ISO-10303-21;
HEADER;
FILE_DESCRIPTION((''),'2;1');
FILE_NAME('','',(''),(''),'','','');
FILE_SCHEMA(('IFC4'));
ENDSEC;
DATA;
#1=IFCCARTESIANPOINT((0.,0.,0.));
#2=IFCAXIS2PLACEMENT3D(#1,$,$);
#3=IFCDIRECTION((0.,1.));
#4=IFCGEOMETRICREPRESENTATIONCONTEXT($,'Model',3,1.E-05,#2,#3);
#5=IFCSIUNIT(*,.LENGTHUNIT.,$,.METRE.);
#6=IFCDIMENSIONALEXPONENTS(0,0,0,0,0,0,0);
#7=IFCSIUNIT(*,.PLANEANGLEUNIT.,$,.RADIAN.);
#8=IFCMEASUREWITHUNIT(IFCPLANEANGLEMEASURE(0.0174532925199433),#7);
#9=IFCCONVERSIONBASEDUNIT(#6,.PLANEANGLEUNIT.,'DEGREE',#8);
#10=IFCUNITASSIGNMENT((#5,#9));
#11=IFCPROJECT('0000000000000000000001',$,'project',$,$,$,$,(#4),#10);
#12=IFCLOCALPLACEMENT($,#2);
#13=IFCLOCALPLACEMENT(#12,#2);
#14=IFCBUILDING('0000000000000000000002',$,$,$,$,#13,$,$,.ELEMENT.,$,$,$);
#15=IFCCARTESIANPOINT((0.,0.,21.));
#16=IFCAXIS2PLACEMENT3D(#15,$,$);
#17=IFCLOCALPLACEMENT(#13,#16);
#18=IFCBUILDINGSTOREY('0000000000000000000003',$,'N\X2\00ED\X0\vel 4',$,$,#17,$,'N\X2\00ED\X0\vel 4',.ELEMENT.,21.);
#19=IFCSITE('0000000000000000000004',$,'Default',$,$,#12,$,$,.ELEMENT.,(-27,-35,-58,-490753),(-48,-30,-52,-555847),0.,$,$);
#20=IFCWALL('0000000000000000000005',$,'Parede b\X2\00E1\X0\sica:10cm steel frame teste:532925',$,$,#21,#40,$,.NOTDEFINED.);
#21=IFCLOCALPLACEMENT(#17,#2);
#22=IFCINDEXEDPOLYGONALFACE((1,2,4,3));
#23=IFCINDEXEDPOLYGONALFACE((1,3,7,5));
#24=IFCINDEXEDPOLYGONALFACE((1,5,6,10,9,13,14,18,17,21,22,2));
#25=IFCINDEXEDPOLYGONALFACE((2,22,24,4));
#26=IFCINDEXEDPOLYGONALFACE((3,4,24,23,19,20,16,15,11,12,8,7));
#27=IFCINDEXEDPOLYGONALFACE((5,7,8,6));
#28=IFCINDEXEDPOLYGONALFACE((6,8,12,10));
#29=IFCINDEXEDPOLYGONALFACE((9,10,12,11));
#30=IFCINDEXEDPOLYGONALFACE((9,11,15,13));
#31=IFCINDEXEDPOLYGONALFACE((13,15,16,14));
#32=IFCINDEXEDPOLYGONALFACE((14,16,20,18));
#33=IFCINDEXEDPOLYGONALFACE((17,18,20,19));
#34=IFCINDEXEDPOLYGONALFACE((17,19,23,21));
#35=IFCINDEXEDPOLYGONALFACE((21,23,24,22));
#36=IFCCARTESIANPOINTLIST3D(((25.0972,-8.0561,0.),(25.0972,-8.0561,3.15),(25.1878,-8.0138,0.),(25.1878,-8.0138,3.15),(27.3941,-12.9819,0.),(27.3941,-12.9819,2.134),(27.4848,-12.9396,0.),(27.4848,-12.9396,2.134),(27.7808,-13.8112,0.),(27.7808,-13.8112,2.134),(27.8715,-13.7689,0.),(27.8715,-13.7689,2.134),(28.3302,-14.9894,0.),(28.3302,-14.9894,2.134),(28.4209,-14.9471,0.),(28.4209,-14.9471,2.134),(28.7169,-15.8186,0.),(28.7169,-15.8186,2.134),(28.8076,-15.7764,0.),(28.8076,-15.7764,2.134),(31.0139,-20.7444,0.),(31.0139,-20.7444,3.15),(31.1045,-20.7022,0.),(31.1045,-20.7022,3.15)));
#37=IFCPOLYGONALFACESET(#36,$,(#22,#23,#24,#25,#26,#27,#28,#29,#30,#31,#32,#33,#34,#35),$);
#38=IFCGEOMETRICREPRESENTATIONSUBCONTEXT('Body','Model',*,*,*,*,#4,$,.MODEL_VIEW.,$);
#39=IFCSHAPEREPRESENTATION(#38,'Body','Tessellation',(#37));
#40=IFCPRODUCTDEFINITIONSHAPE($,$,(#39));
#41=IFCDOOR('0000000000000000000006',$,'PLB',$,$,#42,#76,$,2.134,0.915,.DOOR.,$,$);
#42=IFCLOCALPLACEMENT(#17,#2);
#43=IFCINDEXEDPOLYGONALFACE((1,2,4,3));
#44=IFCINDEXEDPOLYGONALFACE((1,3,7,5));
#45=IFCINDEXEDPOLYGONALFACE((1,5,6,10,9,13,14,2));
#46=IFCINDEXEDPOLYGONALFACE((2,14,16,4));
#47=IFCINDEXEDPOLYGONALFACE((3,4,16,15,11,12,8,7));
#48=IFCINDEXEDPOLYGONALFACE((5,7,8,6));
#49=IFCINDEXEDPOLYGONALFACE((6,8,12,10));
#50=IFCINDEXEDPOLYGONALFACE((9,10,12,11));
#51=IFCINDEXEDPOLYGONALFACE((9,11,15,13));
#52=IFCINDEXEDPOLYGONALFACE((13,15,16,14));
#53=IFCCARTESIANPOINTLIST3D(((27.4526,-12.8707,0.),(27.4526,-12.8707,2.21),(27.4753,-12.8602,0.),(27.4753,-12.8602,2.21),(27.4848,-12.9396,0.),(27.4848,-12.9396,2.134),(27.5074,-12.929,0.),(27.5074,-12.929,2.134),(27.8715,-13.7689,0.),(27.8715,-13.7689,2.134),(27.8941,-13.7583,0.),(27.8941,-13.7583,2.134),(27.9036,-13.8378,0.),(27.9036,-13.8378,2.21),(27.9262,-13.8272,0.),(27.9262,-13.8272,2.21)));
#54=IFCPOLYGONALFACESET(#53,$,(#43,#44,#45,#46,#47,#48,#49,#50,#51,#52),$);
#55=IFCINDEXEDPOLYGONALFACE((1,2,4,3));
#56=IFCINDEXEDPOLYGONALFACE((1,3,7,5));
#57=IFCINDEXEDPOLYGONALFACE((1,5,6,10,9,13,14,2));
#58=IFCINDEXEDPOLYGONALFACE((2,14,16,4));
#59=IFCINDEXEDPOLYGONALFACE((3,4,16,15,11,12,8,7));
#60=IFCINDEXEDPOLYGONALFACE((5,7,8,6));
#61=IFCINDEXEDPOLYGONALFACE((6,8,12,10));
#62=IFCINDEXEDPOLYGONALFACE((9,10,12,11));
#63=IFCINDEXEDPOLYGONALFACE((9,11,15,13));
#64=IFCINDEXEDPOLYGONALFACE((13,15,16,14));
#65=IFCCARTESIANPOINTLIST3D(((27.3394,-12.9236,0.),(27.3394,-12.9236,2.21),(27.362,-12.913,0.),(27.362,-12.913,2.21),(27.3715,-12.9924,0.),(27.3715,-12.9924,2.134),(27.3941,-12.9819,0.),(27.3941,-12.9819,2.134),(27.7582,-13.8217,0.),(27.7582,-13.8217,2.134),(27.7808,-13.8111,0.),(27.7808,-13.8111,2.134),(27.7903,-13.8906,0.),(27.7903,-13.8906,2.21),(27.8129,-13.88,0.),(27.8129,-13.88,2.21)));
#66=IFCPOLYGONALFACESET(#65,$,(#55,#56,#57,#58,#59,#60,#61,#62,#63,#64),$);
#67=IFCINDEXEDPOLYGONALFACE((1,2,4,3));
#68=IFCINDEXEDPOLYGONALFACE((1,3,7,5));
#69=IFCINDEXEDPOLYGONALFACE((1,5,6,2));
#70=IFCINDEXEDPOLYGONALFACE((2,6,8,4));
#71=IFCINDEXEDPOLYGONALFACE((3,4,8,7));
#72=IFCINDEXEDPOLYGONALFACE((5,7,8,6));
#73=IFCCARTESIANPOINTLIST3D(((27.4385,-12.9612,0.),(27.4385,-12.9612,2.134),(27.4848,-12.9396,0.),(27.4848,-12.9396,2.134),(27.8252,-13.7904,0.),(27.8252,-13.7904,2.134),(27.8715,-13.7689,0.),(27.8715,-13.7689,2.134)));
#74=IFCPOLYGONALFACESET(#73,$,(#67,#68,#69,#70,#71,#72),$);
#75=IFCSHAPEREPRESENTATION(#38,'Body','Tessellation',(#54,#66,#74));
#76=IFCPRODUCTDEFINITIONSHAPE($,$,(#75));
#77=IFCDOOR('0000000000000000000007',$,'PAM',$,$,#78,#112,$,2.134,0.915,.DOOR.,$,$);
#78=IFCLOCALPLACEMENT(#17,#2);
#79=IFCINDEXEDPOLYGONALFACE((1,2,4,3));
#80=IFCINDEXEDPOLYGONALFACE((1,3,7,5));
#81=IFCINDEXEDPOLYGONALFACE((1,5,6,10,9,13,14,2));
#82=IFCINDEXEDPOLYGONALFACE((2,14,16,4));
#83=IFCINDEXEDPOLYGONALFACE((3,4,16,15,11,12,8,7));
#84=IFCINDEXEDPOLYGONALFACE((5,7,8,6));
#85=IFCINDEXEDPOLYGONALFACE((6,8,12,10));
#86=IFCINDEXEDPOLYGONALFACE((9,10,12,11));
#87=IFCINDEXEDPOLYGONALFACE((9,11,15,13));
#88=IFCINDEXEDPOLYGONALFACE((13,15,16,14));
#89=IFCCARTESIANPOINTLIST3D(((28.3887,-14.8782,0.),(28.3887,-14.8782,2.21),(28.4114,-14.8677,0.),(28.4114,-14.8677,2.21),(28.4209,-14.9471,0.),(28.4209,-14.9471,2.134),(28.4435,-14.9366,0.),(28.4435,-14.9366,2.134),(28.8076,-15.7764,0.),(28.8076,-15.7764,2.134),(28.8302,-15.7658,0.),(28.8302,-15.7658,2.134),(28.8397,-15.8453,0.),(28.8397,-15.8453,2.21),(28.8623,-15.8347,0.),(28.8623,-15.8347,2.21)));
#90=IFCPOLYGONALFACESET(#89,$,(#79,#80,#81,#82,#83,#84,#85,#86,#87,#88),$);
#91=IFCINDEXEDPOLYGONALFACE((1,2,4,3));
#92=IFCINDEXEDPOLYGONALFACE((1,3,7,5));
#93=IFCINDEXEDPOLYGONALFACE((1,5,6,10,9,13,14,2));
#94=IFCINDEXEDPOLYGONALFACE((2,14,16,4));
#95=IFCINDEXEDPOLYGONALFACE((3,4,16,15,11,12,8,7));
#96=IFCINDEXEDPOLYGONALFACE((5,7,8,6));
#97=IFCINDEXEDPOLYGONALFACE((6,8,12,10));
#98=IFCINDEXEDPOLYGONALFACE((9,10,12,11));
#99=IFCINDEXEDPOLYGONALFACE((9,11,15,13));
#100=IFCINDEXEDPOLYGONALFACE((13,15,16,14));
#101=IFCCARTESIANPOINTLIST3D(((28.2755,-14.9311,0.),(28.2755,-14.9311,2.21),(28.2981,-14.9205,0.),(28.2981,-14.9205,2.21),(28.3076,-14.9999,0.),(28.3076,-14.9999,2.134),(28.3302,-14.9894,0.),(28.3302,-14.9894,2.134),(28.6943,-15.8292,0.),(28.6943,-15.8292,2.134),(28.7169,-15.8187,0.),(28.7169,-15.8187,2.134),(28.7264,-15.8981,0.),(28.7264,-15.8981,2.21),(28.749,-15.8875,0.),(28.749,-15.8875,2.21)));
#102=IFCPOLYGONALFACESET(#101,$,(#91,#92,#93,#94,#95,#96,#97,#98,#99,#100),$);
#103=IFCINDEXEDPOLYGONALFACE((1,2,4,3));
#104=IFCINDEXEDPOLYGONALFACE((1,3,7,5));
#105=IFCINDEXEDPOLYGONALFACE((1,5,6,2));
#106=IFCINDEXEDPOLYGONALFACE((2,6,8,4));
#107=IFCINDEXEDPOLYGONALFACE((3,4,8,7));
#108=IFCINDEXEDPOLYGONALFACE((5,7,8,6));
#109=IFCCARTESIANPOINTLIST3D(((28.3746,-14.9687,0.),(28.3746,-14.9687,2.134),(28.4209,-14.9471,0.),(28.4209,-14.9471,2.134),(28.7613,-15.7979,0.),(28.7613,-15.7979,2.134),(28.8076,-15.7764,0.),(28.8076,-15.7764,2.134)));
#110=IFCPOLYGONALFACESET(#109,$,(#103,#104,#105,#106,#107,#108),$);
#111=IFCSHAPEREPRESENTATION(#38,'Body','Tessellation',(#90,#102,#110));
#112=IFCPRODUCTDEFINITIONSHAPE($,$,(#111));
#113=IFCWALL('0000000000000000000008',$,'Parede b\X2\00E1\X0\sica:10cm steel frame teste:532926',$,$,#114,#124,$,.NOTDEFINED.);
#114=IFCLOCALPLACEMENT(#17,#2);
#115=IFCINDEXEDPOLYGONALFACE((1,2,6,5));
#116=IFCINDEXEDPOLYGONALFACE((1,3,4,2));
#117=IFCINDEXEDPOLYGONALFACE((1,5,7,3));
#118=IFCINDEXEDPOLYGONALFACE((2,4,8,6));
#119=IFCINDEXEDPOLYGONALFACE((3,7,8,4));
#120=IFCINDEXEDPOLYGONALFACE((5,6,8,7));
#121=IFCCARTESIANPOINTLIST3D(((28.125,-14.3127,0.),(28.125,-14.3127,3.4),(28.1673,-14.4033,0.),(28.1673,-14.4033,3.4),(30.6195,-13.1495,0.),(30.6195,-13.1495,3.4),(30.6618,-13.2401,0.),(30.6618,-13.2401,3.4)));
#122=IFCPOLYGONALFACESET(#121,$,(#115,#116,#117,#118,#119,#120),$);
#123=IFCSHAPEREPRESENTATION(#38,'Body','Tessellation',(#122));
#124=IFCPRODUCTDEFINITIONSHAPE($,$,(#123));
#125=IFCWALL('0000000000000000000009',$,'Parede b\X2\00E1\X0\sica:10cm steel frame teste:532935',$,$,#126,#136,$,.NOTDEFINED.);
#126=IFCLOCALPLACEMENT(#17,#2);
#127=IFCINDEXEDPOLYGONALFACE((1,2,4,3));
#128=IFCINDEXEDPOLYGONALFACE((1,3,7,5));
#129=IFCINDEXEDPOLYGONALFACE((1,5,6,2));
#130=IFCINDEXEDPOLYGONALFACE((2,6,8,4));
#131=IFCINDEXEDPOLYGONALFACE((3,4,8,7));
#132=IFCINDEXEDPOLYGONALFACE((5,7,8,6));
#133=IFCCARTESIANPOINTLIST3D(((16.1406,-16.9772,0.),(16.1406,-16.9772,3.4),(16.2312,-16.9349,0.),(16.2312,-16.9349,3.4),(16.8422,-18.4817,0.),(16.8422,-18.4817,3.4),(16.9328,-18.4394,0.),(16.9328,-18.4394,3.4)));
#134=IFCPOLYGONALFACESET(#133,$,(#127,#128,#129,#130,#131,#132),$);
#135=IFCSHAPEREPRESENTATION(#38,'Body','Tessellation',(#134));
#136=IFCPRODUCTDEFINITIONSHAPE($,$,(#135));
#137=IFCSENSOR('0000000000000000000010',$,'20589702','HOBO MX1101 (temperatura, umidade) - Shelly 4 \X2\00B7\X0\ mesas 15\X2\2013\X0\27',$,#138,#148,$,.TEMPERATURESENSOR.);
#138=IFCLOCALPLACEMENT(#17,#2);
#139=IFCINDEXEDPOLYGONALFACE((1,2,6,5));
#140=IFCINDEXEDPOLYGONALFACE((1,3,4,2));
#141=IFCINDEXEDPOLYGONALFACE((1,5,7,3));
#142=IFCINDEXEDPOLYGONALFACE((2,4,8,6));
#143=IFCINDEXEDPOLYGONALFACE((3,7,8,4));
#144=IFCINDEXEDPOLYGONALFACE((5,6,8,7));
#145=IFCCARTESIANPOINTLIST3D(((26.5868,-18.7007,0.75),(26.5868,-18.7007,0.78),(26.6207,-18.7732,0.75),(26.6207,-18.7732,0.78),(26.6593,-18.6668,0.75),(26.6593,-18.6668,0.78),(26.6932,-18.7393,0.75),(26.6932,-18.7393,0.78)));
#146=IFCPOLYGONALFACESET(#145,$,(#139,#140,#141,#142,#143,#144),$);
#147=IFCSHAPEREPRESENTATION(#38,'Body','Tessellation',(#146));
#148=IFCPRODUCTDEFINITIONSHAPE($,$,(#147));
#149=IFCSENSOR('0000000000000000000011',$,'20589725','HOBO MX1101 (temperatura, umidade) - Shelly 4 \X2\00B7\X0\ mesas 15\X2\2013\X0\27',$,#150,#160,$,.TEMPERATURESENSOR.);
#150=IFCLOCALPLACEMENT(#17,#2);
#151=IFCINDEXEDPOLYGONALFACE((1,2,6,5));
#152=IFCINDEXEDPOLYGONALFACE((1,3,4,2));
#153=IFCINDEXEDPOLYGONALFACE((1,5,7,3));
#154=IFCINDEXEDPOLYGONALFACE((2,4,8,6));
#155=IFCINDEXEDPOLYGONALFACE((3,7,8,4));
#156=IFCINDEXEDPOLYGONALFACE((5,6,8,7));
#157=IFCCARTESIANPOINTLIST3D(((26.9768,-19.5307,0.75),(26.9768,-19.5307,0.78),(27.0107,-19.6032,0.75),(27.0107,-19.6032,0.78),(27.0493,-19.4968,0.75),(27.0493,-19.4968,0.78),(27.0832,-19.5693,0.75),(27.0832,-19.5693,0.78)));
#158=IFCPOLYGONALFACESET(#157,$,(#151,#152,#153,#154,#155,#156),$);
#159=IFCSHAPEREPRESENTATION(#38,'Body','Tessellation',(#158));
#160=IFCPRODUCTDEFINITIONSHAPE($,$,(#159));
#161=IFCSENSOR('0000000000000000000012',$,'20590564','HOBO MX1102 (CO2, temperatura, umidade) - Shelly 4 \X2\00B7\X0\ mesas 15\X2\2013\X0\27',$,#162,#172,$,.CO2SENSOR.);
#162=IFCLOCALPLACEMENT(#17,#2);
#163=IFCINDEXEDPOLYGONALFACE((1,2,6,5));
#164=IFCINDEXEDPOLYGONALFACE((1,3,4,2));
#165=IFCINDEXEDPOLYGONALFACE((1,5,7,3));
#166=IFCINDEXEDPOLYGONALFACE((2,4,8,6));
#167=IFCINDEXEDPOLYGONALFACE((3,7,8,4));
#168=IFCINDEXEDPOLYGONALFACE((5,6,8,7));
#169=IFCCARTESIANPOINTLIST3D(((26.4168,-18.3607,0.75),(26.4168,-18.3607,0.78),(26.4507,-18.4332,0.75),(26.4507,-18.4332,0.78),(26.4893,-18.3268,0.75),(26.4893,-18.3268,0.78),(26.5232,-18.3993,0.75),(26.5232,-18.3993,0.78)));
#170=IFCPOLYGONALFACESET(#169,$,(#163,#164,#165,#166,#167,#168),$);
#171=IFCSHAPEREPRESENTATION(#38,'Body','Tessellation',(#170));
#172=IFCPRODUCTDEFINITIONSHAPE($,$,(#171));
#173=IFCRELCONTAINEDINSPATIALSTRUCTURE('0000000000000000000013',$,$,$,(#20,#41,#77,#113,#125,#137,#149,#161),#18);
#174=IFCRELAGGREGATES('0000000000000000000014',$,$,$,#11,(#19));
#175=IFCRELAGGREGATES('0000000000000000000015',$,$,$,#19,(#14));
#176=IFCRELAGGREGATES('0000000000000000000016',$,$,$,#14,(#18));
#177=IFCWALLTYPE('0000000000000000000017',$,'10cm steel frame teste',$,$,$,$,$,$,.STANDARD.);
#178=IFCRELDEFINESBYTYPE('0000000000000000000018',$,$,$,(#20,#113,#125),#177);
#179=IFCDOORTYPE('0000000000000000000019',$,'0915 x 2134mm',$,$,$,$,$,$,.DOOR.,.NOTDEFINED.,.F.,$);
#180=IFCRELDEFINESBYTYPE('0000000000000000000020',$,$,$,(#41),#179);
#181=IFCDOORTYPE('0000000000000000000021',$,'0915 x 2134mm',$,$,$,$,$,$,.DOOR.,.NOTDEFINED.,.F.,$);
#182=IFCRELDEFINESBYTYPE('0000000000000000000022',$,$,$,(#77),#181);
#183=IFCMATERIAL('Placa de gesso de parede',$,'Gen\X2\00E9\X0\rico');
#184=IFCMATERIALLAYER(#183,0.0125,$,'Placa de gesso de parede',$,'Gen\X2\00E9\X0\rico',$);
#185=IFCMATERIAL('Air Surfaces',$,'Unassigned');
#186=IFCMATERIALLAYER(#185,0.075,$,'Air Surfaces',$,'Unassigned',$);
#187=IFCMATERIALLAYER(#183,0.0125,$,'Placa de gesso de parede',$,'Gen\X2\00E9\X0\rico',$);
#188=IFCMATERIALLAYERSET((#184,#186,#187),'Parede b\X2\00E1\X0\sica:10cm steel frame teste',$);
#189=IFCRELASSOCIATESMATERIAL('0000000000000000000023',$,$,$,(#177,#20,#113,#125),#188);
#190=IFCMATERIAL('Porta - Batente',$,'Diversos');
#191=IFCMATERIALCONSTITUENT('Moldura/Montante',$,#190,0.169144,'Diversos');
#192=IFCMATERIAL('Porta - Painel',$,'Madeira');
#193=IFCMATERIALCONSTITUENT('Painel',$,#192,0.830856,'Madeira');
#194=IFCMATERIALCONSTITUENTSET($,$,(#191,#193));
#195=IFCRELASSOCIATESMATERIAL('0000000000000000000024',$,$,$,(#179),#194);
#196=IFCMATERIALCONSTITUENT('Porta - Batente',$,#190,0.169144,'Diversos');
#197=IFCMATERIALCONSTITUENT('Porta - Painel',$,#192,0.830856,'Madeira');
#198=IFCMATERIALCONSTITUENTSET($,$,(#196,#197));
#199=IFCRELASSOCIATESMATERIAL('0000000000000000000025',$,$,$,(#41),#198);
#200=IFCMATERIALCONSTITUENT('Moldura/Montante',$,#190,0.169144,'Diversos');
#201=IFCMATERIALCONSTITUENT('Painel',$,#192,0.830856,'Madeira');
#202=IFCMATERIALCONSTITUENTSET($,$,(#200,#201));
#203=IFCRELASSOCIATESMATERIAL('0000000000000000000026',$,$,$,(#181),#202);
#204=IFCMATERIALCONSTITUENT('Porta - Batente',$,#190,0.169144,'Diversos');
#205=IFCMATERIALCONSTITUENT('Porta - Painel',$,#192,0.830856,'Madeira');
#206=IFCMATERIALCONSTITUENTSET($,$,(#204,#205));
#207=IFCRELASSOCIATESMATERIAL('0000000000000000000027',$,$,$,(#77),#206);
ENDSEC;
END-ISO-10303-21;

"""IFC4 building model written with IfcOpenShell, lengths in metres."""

from ifc_helpers import new_model, entity, si_unit, converted_unit, direction, frame, frame_2d, origin, origin_2d, origin_2d_with_axis, place, context, subcontext, project, spatial, polyline, rectangle, outline, extrude, source, transform, mapped, material, layer, layer_set, layer_usage, constituent, constituent_set, type_object, type_shapes, element, fill, save


model = new_model("IFC4")

# Units and contexts
model_context = context("Model", 3, precision=1e-05, world=origin(), true_north=direction((0.0, 1.0)))
body_context = subcontext(model_context, "Body", "Model", "MODEL_VIEW")
ifc_project = project(units=[si_unit("LENGTHUNIT", "METRE"), converted_unit("PLANEANGLEUNIT", "DEGREE", entity("IfcPlaneAngleMeasure", 0.0174532925199433), si_unit("PLANEANGLEUNIT", "RADIAN"), dimensions=[0, 0, 0, 0, 0, 0, 0])], contexts=[model_context])

# Site, building, storey
site_placement = place(None, origin())
site = spatial("IfcSite", under=ifc_project, at=site_placement, Name="Default", CompositionType="ELEMENT", RefLatitude=(-27, -35, -58, -490753), RefLongitude=(-48, -30, -52, -555847), RefElevation=0.0)
building_placement = place(site_placement, origin())
building = spatial("IfcBuilding", under=site, at=building_placement, CompositionType="ELEMENT")
storey_placement = place(building_placement, frame((0.0, 0.0, 21.0)))
storey = spatial("IfcBuildingStorey", under=building, at=storey_placement, Name="Nível 4", LongName="Nível 4", CompositionType="ELEMENT", Elevation=21.0)

# Shared definitions
ifc_material_1 = material(Name="Placa de gesso de parede", Category="Genérico")
ifc_layer_1 = layer(ifc_material_1, 0.0125, Name="Placa de gesso de parede", Category="Genérico")
ifc_material_2 = material(Name="Air Surfaces", Category="Unassigned")
ifc_layer_2 = layer(ifc_material_2, 0.075, Name="Air Surfaces", Category="Unassigned")
ifc_layer_3 = layer(ifc_material_1, 0.0125, Name="Placa de gesso de parede", Category="Genérico")
ifc_layer_set_1 = layer_set([ifc_layer_1, ifc_layer_2, ifc_layer_3], Name="Parede básica:10cm steel frame teste")
wall_type_1 = type_object("IfcWallType", Name="10cm steel frame teste", PredefinedType="STANDARD", material=ifc_layer_set_1)

# Shared definitions
ifc_material_3 = material(Name="Porta - Batente", Category="Diversos")
ifc_material_4 = material(Name="Porta - Painel", Category="Madeira")

# Wall, openings, doors
ifc_layer_usage_1 = layer_usage(ifc_layer_set_1, "AXIS2", "NEGATIVE", 0.05)
wall_1_placement = place(storey_placement, frame((25.1425, -8.035, 0.0), z_axis=(0.0, 0.0, 1.0), x_axis=(0.422618, -0.906308, 0.0)))
wall_1 = element("IfcWall", 1, at=wall_1_placement, inside=storey, type_object=wall_type_1, material=ifc_layer_usage_1, Name="Parede básica:10cm steel frame teste:532925", PredefinedType="NOTDEFINED", context=body_context, shape_type="SweptSolid", body=[
    extrude(rectangle(XDim=14.0, YDim=0.1, at=frame_2d((7.0, 0.0), x_axis=(-1.0, 0.0))), origin(), (0.0, 0.0, 1.0), 3.15),
])
opening_1_placement = place(wall_1_placement, frame((5.435, -0.05, 0.0)))
opening_1 = element("IfcOpeningElement", 2, at=opening_1_placement, cuts=wall_1, PredefinedType="OPENING", context=body_context, shape_type="SweptSolid", body=[
    extrude(rectangle(XDim=0.915, YDim=2.134, at=frame_2d((1.067, 0.4575), x_axis=(0.0, 1.0))), frame((0.0, 0.0, 0.0), z_axis=(0.0, 1.0, 0.0), x_axis=(0.0, 0.0, 1.0)), (0.0, 0.0, 1.0), 0.1),
])
opening_2_placement = place(wall_1_placement, frame((7.65, -0.05, 0.0)))
opening_2 = element("IfcOpeningElement", 3, at=opening_2_placement, cuts=wall_1, PredefinedType="OPENING", context=body_context, shape_type="SweptSolid", body=[
    extrude(rectangle(XDim=0.915, YDim=2.134, at=frame_2d((1.067, 0.4575), x_axis=(0.0, -1.0))), frame((0.0, 0.0, 0.0), z_axis=(0.0, 1.0, 0.0), x_axis=(0.0, 0.0, 1.0)), (0.0, 0.0, 1.0), 0.1),
])
ifc_constituent_1 = constituent(ifc_material_3, Name="Porta - Batente", Category="Diversos", fraction=0.169144)
ifc_constituent_2 = constituent(ifc_material_4, Name="Porta - Painel", Category="Madeira", fraction=0.830856)
ifc_constituent_set_1 = constituent_set(constituents=[ifc_constituent_1, ifc_constituent_2])
ifc_constituent_3 = constituent(ifc_material_3, Name="Moldura/Montante", Category="Diversos", fraction=0.169144)
ifc_constituent_4 = constituent(ifc_material_4, Name="Painel", Category="Madeira", fraction=0.830856)
ifc_constituent_set_2 = constituent_set(constituents=[ifc_constituent_3, ifc_constituent_4])
door_type_1 = type_object("IfcDoorType", Name="0915 x 2134mm", OperationType="NOTDEFINED", ParameterTakesPrecedence=False, PredefinedType="DOOR", material=ifc_constituent_set_2)
shared_shape_1 = source(origin(), body_context, "Body", "SweptSolid", [
    extrude(outline(polyline([(-0.5335, -1.124), (0.5335, -1.124), (0.5335, 1.086), (0.4575, 1.086), (0.4575, -1.048), (-0.4575, -1.048), (-0.4575, 1.086), (-0.5335, 1.086), (-0.5335, -1.124)])), frame((0.4575, 0.1, 1.086), z_axis=(0.0, 1.0, 0.0), x_axis=(1.0, 0.0, 0.0)), (0.0, 0.0, 1.0), 0.025),
    extrude(outline(polyline([(-1.124, -0.5335), (1.086, -0.5335), (1.086, -0.4575), (-1.048, -0.4575), (-1.048, 0.4575), (1.086, 0.4575), (1.086, 0.5335), (-1.124, 0.5335), (-1.124, -0.5335)])), frame((0.4575, -0.025, 1.086), z_axis=(0.0, 1.0, 0.0), x_axis=(0.0, 0.0, -1.0)), (0.0, 0.0, 1.0), 0.025),
    extrude(rectangle(XDim=0.051, YDim=0.915, at=origin_2d_with_axis()), frame((0.4575, 0.0745, 0.0), z_axis=(0.0, 0.0, 1.0), x_axis=(0.0, 1.0, 0.0)), (0.0, 0.0, 1.0), 2.134),
])
type_shapes(door_type_1, [shared_shape_1])
door_1_placement = place(opening_1_placement, frame((0.0, 0.0, 0.0), z_axis=(0.0, 0.0, 1.0), x_axis=(1.0, 0.0, 0.0)))
door_1 = element("IfcDoor", 4, at=door_1_placement, inside=storey, type_object=door_type_1, material=ifc_constituent_set_1, Name="PLB", OverallHeight=2.134, OverallWidth=0.915, PredefinedType="DOOR", context=body_context, shape_type="MappedRepresentation", body=[
    mapped(shared_shape_1, transform((0.0, 0.0, 0.0), scale=1.0)),
])
fill(opening_1, door_1)
ifc_constituent_5 = constituent(ifc_material_3, Name="Porta - Batente", Category="Diversos", fraction=0.169144)
ifc_constituent_6 = constituent(ifc_material_4, Name="Porta - Painel", Category="Madeira", fraction=0.830856)
ifc_constituent_set_3 = constituent_set(constituents=[ifc_constituent_5, ifc_constituent_6])
ifc_constituent_7 = constituent(ifc_material_3, Name="Moldura/Montante", Category="Diversos", fraction=0.169144)
ifc_constituent_8 = constituent(ifc_material_4, Name="Painel", Category="Madeira", fraction=0.830856)
ifc_constituent_set_4 = constituent_set(constituents=[ifc_constituent_7, ifc_constituent_8])
door_type_2 = type_object("IfcDoorType", Name="0915 x 2134mm", OperationType="NOTDEFINED", ParameterTakesPrecedence=False, PredefinedType="DOOR", material=ifc_constituent_set_4)
shared_shape_2 = source(origin(), body_context, "Body", "SweptSolid", [
    extrude(outline(polyline([(-0.5335, -1.124), (0.5335, -1.124), (0.5335, 1.086), (0.4575, 1.086), (0.4575, -1.048), (-0.4575, -1.048), (-0.4575, 1.086), (-0.5335, 1.086), (-0.5335, -1.124)])), frame((0.4575, 0.125, 1.086), z_axis=(0.0, -1.0, 0.0), x_axis=(-1.0, 0.0, 0.0)), (0.0, 0.0, 1.0), 0.025),
    extrude(outline(polyline([(-1.124, -0.5335), (1.086, -0.5335), (1.086, -0.4575), (-1.048, -0.4575), (-1.048, 0.4575), (1.086, 0.4575), (1.086, 0.5335), (-1.124, 0.5335), (-1.124, -0.5335)])), frame((0.4575, 0.0, 1.086), z_axis=(0.0, -1.0, 0.0), x_axis=(0.0, 0.0, -1.0)), (0.0, 0.0, 1.0), 0.025),
    extrude(rectangle(XDim=0.915, YDim=0.051, at=origin_2d_with_axis()), frame((0.4575, 0.0745, 0.0)), (0.0, 0.0, 1.0), 2.134),
])
type_shapes(door_type_2, [shared_shape_2])
door_2_placement = place(opening_2_placement, frame((0.0, 0.0, 0.0), z_axis=(0.0, 0.0, 1.0), x_axis=(1.0, 0.0, 0.0)))
door_2 = element("IfcDoor", 5, at=door_2_placement, inside=storey, type_object=door_type_2, material=ifc_constituent_set_3, Name="PAM", OverallHeight=2.134, OverallWidth=0.915, PredefinedType="DOOR", context=body_context, shape_type="MappedRepresentation", body=[
    mapped(shared_shape_2, transform((0.0, 0.0, 0.0), scale=1.0)),
])
fill(opening_2, door_2)

# Walls
ifc_layer_usage_2 = layer_usage(ifc_layer_set_1, "AXIS2", "NEGATIVE", 0.05)
wall_2_placement = place(storey_placement, frame((28.1462, -14.358, 0.0), z_axis=(0.0, 0.0, 1.0), x_axis=(0.906308, 0.422618, 0.0)))
element("IfcWall", 6, at=wall_2_placement, inside=storey, type_object=wall_type_1, material=ifc_layer_usage_2, Name="Parede básica:10cm steel frame teste:532926", PredefinedType="NOTDEFINED", context=body_context, shape_type="SweptSolid", body=[
    extrude(rectangle(XDim=2.7524, YDim=0.1, at=frame_2d((1.3762, 0.0), x_axis=(-1.0, 0.0))), origin(), (0.0, 0.0, 1.0), 3.4),
])
ifc_layer_usage_3 = layer_usage(ifc_layer_set_1, "AXIS2", "NEGATIVE", 0.05)
wall_3_placement = place(storey_placement, frame((16.1859, -16.9561, 0.0), z_axis=(0.0, 0.0, 1.0), x_axis=(0.422618, -0.906308, 0.0)))
element("IfcWall", 7, at=wall_3_placement, inside=storey, type_object=wall_type_1, material=ifc_layer_usage_3, Name="Parede básica:10cm steel frame teste:532935", PredefinedType="NOTDEFINED", context=body_context, shape_type="SweptSolid", body=[
    extrude(rectangle(XDim=1.66, YDim=0.1, at=frame_2d((0.83, 0.0), x_axis=(-1.0, 0.0))), origin(), (0.0, 0.0, 1.0), 3.4),
])

# Sensors
for number, where, z_axis, x_axis, name in (
    (8, (26.64, -18.72, 21.75), (0.0, 0.0, 1.0), (0.906245, 0.422754, 0.0), "20589702"),
    (9, (27.03, -19.55, 21.75), (0.0, 0.0, 1.0), (0.906245, 0.422754, 0.0), "20589725"),
):
    element("IfcSensor", number, at=place(None, frame(where, z_axis=z_axis, x_axis=x_axis)), inside=storey, Name=name, Description="HOBO MX1101 (temperatura, umidade) - Shelly 4 · mesas 15–27", PredefinedType="TEMPERATURESENSOR", context=body_context, shape_type="SweptSolid", body=[
        extrude(rectangle(XDim=0.08, YDim=0.08, at=origin_2d()), None, (0.0, 0.0, 1.0), 0.03),
    ])
sensor_placement = place(None, frame((26.47, -18.38, 21.75), z_axis=(0.0, 0.0, 1.0), x_axis=(0.906245, 0.422754, 0.0)))
element("IfcSensor", 10, at=sensor_placement, inside=storey, Name="20590564", Description="HOBO MX1102 (CO2, temperatura, umidade) - Shelly 4 · mesas 15–27", PredefinedType="CO2SENSOR", context=body_context, shape_type="SweptSolid", body=[
    extrude(rectangle(XDim=0.08, YDim=0.08, at=origin_2d()), None, (0.0, 0.0, 1.0), 0.03),
])

save(model, "model.ifc")
